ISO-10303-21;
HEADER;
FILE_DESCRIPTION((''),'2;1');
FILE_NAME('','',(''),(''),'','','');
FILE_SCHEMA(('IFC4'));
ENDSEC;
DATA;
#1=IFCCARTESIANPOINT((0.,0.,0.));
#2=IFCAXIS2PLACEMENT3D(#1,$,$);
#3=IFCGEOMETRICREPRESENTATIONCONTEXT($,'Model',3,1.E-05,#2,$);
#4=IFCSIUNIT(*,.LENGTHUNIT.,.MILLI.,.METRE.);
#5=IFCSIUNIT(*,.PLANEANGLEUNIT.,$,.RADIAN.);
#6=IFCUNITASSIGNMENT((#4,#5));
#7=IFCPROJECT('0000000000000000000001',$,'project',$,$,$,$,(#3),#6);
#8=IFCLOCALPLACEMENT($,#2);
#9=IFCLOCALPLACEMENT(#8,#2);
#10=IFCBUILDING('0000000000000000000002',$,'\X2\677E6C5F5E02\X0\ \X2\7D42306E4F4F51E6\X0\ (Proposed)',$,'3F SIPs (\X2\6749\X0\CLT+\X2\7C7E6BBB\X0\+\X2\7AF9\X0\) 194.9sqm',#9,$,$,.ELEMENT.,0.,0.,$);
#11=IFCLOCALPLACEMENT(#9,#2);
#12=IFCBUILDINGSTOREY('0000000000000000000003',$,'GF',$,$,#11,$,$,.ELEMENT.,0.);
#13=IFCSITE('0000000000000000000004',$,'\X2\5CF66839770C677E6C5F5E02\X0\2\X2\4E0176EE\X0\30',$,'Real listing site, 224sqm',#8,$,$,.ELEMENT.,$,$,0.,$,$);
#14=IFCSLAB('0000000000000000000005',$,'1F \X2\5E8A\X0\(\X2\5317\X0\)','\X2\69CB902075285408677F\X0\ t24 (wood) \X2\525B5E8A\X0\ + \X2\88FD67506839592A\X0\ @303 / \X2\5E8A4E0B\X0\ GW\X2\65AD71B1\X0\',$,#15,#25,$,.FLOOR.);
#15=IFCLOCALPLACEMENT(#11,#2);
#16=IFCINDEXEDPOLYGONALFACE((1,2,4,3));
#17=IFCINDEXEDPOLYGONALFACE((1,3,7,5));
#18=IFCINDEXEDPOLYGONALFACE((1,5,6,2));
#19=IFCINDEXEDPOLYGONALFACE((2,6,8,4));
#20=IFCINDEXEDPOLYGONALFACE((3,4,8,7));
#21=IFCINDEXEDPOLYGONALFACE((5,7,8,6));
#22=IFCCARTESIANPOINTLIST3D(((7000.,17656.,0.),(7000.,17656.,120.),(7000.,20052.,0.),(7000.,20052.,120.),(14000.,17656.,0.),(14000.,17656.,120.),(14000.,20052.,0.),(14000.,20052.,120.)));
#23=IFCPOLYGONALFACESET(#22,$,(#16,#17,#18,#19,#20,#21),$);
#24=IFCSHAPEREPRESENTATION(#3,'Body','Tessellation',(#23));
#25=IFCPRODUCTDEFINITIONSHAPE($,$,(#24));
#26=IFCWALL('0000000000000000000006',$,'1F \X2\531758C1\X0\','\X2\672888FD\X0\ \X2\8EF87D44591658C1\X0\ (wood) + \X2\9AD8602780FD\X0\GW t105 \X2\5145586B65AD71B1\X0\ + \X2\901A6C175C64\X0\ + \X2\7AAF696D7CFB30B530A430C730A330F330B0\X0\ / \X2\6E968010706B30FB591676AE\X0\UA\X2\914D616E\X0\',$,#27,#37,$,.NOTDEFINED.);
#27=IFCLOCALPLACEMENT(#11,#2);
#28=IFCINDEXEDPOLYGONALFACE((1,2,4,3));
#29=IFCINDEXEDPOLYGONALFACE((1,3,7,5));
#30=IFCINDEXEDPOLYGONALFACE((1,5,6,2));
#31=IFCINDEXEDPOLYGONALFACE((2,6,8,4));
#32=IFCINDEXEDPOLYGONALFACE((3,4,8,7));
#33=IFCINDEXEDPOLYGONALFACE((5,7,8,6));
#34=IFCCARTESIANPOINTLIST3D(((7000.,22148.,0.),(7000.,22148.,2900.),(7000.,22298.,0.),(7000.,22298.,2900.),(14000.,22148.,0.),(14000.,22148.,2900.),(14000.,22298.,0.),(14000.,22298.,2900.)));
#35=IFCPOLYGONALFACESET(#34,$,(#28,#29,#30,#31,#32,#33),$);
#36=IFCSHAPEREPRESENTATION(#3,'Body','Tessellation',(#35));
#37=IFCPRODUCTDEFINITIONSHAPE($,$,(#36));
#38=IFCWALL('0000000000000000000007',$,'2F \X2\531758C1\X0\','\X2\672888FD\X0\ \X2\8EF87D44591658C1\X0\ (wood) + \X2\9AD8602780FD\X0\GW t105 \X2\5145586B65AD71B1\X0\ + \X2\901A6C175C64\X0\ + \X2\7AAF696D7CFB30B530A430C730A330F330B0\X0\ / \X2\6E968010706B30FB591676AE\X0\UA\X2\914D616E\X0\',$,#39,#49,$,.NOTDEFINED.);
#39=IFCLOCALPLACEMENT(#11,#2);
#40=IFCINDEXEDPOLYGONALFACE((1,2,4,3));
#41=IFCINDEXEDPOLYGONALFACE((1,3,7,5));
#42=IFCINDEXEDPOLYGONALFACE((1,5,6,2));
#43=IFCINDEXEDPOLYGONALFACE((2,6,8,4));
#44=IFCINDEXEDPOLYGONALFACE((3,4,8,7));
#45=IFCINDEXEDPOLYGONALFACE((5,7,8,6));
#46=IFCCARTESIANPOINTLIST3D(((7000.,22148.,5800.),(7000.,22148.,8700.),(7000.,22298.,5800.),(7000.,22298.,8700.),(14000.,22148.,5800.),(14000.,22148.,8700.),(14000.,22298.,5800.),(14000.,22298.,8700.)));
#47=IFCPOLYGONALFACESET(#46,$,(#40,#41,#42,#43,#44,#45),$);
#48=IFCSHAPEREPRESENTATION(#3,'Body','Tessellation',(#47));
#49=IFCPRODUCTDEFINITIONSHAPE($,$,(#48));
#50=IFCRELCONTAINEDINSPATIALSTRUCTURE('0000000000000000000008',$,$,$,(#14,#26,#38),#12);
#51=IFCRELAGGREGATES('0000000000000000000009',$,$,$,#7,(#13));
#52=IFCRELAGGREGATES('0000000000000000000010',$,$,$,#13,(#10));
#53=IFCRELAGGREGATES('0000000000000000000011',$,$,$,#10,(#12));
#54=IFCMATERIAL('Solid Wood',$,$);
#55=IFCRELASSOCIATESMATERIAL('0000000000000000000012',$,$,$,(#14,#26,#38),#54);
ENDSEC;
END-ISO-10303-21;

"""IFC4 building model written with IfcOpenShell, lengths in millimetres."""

from ifc_helpers import new_model, si_unit, frame, frame_2d, origin, place, context, project, spatial, rectangle, extrude, material, element, save


model = new_model("IFC4")

# Units and contexts
model_context = context("Model", 3, precision=1e-05, world=origin())
ifc_project = project(units=[si_unit("LENGTHUNIT", "METRE", prefix="MILLI"), si_unit("PLANEANGLEUNIT", "RADIAN")], contexts=[model_context])

# Site, building, storey
site_placement = place(None, origin())
site = spatial("IfcSite", under=ifc_project, at=site_placement, Name="島根県松江市2丁目30", ObjectType="Real listing site, 224sqm", CompositionType="ELEMENT", RefElevation=0.0)
building_placement = place(site_placement, origin())
building = spatial("IfcBuilding", under=site, at=building_placement, Name="松江市 終の住処 (Proposed)", ObjectType="3F SIPs (杉CLT+籾殻+竹) 194.9sqm", CompositionType="ELEMENT", ElevationOfRefHeight=0.0, ElevationOfTerrain=0.0)
storey_placement = place(building_placement, origin())
storey = spatial("IfcBuildingStorey", under=building, at=storey_placement, Name="GF", CompositionType="ELEMENT", Elevation=0.0)

# Slab
ifc_material_1 = material(Name="Solid Wood")
slab_1_placement = place(storey_placement, frame((3500.0, 8828.0, 0.0)))
element("IfcSlab", 1, at=slab_1_placement, inside=storey, material=ifc_material_1, Name="1F 床(北)", Description="構造用合板 t24 (wood) 剛床 + 製材根太 @303 / 床下 GW断熱", PredefinedType="FLOOR", context=model_context, shape_type="SweptSolid", body=[
    extrude(rectangle(XDim=7000.0, YDim=2396.0, at=frame_2d((3500.0, 1198.0))), frame((3500.0, 8828.0, 0.0)), (0.0, 0.0, 1.0), 120.0),
])

# Wall
wall_1_placement = place(storey_placement, frame((3500.0, 11074.0, 0.0)))
element("IfcWall", 2, at=wall_1_placement, inside=storey, material=ifc_material_1, Name="1F 北壁", Description="木製 軸組外壁 (wood) + 高性能GW t105 充填断熱 + 通気層 + 窯業系サイディング / 準耐火・外皮UA配慮", PredefinedType="NOTDEFINED", context=model_context, shape_type="SweptSolid", body=[
    extrude(rectangle(XDim=7000.0, YDim=150.0, at=frame_2d((3500.0, 75.0))), frame((3500.0, 11074.0, 0.0)), (0.0, 0.0, 1.0), 2900.0),
])

# Wall
wall_2_placement = place(storey_placement, frame((3500.0, 11074.0, 2900.0)))
element("IfcWall", 3, at=wall_2_placement, inside=storey, material=ifc_material_1, Name="2F 北壁", Description="木製 軸組外壁 (wood) + 高性能GW t105 充填断熱 + 通気層 + 窯業系サイディング / 準耐火・外皮UA配慮", PredefinedType="NOTDEFINED", context=model_context, shape_type="SweptSolid", body=[
    extrude(rectangle(XDim=7000.0, YDim=150.0, at=frame_2d((3500.0, 75.0))), frame((3500.0, 11074.0, 2900.0)), (0.0, 0.0, 1.0), 2900.0),
])

save(model, "model.ifc")
